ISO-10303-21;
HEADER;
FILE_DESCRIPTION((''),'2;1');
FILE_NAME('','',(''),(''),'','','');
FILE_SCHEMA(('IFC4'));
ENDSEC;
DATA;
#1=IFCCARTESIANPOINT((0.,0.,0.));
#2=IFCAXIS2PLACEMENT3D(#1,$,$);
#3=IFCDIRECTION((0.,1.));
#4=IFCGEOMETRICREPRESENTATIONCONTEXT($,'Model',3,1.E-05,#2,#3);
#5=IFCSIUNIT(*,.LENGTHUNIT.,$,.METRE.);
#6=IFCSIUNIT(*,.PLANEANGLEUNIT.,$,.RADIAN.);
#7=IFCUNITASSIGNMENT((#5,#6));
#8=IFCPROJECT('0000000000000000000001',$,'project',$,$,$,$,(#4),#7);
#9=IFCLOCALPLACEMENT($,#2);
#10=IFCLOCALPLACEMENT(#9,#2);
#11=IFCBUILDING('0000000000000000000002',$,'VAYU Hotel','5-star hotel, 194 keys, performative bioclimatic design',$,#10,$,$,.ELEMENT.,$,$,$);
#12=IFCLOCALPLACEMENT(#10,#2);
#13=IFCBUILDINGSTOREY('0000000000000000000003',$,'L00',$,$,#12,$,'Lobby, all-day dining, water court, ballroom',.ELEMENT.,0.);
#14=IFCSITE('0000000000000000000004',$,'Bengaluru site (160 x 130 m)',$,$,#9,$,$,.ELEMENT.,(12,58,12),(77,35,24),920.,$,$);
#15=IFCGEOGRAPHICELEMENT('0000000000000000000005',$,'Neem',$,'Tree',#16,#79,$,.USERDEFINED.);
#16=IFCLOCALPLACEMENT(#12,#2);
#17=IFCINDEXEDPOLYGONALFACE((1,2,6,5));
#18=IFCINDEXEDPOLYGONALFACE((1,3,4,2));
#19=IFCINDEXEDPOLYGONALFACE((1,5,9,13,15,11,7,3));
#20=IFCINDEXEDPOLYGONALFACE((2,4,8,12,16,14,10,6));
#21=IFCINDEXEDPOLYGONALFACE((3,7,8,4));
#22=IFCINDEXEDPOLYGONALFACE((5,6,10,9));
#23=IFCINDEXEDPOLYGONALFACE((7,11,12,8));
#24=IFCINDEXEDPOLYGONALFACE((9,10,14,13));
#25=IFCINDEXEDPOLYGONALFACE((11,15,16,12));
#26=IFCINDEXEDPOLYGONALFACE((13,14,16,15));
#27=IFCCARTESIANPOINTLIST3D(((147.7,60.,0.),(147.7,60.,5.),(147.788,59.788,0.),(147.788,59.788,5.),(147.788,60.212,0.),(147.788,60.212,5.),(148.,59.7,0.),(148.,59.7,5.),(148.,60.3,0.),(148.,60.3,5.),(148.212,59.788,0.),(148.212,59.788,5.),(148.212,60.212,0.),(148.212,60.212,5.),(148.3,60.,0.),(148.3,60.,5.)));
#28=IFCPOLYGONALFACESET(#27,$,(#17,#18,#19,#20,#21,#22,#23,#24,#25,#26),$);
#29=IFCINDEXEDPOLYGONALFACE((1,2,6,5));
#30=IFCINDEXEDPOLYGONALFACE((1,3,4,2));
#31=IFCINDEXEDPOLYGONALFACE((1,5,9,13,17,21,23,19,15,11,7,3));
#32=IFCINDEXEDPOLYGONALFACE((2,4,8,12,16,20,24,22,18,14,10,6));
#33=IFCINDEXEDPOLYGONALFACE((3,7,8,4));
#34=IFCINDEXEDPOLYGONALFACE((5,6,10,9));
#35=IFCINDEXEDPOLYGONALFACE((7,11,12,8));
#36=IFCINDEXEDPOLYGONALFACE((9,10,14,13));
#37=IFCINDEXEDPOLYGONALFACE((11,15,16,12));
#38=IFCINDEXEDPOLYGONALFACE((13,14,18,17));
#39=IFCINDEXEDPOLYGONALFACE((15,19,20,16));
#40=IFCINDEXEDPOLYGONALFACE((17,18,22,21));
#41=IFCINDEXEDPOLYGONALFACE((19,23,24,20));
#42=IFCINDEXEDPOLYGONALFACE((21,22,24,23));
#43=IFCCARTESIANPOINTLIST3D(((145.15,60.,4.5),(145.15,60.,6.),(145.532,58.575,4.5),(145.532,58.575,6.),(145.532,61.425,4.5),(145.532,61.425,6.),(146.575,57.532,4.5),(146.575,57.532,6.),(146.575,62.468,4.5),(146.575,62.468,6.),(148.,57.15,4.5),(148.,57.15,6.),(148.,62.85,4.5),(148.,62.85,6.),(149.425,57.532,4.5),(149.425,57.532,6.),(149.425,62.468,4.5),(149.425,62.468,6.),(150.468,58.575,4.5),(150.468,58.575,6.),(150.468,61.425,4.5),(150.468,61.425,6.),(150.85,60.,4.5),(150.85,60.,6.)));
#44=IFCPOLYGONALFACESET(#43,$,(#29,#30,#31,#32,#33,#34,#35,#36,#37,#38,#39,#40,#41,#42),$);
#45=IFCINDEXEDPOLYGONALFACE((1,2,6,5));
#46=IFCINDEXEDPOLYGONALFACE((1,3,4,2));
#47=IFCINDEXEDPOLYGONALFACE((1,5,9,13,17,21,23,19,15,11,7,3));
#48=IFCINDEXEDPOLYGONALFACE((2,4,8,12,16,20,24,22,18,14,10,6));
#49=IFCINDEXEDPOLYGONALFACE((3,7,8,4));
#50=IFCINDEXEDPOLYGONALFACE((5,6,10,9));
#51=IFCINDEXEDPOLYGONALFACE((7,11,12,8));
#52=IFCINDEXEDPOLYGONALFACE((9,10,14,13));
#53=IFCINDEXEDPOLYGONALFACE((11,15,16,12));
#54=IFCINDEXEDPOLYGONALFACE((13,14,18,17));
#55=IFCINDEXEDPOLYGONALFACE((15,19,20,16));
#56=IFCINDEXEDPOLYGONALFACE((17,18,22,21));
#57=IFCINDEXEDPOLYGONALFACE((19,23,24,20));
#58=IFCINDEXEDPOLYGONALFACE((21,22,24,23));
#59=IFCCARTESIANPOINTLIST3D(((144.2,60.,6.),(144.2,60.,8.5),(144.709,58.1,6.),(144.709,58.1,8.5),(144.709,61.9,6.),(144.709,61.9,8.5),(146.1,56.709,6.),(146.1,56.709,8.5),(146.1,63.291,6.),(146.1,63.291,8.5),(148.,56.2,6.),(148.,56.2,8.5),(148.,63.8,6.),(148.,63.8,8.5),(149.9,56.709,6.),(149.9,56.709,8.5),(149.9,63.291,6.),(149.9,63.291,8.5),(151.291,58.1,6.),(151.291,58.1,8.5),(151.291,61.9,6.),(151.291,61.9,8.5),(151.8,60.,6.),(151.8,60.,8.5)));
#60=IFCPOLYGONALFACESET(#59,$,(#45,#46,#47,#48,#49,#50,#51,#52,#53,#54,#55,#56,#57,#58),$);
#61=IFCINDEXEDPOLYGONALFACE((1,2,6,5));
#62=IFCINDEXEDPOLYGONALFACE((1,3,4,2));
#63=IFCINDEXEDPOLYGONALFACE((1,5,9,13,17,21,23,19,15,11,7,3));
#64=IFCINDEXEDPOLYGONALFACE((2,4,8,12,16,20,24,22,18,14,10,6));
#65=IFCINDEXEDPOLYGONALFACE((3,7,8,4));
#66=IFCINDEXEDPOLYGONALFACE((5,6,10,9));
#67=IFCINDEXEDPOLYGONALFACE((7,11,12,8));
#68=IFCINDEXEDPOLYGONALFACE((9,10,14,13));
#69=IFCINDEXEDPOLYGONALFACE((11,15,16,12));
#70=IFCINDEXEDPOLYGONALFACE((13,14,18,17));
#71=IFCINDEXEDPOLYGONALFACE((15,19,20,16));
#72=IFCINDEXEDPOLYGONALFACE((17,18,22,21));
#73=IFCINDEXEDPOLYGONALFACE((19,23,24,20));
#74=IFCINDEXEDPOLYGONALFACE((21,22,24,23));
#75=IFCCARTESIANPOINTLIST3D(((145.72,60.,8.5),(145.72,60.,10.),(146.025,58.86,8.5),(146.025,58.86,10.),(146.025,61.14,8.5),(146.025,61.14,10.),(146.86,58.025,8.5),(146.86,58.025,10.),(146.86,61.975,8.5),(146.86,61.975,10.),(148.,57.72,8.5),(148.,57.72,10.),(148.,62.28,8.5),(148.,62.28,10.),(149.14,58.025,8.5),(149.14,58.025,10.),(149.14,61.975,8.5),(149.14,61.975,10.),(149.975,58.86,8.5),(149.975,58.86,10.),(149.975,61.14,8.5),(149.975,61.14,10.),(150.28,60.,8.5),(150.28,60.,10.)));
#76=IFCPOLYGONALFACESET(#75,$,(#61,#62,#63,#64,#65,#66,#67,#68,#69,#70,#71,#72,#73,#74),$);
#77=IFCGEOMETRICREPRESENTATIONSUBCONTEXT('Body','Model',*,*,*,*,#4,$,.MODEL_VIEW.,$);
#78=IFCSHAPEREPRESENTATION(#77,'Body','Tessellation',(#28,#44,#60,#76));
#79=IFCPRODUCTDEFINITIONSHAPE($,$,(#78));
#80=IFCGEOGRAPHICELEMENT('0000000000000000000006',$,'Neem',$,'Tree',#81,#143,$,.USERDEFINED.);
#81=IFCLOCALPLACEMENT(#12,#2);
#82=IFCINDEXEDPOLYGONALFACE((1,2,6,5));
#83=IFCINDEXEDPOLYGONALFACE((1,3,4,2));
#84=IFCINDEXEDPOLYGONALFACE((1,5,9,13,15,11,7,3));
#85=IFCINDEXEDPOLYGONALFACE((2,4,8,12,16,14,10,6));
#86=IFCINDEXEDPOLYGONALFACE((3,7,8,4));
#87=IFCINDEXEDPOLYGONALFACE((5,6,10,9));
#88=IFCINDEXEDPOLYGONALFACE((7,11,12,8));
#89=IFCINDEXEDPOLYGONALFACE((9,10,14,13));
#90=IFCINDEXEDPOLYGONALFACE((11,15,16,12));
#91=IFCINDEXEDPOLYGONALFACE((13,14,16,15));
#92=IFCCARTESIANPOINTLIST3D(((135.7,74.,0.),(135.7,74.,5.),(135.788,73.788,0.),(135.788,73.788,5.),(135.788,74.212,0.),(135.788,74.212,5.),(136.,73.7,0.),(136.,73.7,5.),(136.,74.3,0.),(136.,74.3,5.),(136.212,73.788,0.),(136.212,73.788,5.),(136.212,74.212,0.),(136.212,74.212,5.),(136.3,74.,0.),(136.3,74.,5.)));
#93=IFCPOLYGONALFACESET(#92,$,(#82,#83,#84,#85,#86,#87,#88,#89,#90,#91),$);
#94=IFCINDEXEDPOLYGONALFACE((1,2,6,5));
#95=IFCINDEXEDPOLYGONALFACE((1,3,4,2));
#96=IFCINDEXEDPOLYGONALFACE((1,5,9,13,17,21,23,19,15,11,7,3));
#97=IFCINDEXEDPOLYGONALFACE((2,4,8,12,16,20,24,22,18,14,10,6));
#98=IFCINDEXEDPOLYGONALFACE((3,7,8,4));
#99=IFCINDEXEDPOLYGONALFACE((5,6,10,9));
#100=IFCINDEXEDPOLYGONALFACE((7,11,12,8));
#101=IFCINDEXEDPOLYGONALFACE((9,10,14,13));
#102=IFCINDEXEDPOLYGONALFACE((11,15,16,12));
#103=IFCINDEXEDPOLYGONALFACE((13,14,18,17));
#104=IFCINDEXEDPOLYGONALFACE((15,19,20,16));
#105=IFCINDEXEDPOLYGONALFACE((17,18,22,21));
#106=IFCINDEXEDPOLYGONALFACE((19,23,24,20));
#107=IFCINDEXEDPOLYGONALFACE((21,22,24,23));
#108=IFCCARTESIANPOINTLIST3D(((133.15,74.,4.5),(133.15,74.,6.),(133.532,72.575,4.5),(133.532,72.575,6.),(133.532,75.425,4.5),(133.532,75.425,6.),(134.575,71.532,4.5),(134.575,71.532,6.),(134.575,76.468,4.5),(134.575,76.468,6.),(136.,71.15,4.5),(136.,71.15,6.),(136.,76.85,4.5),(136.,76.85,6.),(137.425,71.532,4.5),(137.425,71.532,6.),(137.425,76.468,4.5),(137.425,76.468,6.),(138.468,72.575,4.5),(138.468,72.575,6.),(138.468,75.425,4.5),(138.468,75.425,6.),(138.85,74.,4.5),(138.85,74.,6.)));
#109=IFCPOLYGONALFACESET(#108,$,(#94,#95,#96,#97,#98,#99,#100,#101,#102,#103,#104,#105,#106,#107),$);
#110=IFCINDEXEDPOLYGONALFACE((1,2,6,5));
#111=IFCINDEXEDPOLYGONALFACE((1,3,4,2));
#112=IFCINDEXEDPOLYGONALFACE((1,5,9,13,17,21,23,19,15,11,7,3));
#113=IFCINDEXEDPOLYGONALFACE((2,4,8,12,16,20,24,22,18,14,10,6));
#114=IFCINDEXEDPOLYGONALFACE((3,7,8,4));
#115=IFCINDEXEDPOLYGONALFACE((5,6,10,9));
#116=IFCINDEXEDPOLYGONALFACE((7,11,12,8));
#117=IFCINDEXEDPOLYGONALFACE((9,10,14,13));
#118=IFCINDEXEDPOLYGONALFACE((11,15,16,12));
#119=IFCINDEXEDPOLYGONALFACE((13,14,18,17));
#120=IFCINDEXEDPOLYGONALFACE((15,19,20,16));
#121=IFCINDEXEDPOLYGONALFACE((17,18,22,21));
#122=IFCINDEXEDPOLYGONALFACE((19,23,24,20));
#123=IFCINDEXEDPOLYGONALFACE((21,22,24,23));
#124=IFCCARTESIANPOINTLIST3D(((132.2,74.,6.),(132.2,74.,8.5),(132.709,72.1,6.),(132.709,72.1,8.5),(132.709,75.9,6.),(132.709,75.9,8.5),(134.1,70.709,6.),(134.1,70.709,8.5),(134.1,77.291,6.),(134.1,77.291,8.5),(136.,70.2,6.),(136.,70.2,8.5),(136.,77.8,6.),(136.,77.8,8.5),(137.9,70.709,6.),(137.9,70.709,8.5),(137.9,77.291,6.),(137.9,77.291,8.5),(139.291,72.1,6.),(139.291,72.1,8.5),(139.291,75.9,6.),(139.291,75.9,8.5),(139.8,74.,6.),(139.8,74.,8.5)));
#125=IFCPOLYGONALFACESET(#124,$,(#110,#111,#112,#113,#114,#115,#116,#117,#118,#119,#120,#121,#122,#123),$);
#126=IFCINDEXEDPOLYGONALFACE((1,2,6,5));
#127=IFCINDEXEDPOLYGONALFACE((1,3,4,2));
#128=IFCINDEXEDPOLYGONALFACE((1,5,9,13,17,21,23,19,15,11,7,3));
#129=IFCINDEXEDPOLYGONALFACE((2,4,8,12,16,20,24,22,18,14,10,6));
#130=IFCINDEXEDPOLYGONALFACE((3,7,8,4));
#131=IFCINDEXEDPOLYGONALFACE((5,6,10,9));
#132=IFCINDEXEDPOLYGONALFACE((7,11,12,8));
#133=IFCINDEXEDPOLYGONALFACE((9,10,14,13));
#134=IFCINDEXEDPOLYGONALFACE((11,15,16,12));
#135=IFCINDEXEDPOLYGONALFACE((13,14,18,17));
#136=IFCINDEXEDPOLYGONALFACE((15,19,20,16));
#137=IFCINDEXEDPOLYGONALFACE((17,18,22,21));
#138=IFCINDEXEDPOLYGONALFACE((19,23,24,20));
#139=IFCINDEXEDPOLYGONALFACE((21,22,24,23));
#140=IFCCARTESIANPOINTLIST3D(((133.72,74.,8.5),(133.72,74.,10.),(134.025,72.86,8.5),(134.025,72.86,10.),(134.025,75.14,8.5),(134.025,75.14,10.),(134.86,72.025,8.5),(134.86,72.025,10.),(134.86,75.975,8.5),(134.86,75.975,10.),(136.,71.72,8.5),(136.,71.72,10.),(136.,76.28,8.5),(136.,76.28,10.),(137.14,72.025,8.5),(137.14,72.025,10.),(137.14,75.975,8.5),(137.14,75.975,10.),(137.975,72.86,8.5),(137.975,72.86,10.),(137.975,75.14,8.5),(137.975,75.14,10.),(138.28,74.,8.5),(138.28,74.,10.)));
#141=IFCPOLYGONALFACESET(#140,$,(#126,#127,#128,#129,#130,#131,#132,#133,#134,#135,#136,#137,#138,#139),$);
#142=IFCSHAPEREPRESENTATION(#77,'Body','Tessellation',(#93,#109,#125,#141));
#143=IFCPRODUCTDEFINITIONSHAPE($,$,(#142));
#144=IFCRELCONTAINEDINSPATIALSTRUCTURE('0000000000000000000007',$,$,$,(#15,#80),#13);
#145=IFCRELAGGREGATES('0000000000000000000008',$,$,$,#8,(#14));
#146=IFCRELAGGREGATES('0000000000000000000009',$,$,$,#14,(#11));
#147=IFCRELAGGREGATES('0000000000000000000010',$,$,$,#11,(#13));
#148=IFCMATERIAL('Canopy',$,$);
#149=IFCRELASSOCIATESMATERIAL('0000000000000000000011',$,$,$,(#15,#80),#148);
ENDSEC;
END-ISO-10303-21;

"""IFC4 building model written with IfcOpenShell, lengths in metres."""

from ifc_helpers import new_model, si_unit, direction, frame, origin, place, context, subcontext, project, spatial, polyline, outline, extrude, material, element, save


model = new_model("IFC4")

# Units and contexts
model_context = context("Model", 3, precision=1e-05, world=origin(), true_north=direction((0.0, 1.0)))
body_context = subcontext(model_context, "Body", "Model", "MODEL_VIEW")
ifc_project = project(units=[si_unit("LENGTHUNIT", "METRE"), si_unit("PLANEANGLEUNIT", "RADIAN")], contexts=[model_context])

# Site, building, storey
site_placement = place(None, origin())
site = spatial("IfcSite", under=ifc_project, at=site_placement, Name="Bengaluru site (160 x 130 m)", CompositionType="ELEMENT", RefLatitude=(12, 58, 12), RefLongitude=(77, 35, 24), RefElevation=920.0)
building_placement = place(site_placement, origin())
building = spatial("IfcBuilding", under=site, at=building_placement, Name="VAYU Hotel", Description="5-star hotel, 194 keys, performative bioclimatic design", CompositionType="ELEMENT")
storey_placement = place(building_placement, origin())
storey = spatial("IfcBuildingStorey", under=building, at=storey_placement, Name="L00", LongName="Lobby, all-day dining, water court, ballroom", CompositionType="ELEMENT", Elevation=0.0)

# Geographic elements
ifc_material_1 = material(Name="Canopy")
geographic_element_1_placement = place(storey_placement, origin())
element("IfcGeographicElement", 1, at=geographic_element_1_placement, inside=storey, material=ifc_material_1, Name="Neem", ObjectType="Tree", PredefinedType="USERDEFINED", context=body_context, shape_type="SweptSolid", body=[
    extrude(outline(polyline([(148.3, 60.0), (148.212, 60.212), (148.0, 60.3), (147.788, 60.212), (147.7, 60.0), (147.788, 59.788), (148.0, 59.7), (148.212, 59.788), (148.3, 60.0)])), origin(), (0.0, 0.0, 1.0), 5.0),
    extrude(outline(polyline([(150.85, 60.0), (150.468, 61.425), (149.425, 62.468), (148.0, 62.85), (146.575, 62.468), (145.532, 61.425), (145.15, 60.0), (145.532, 58.575), (146.575, 57.532), (148.0, 57.15), (149.425, 57.532), (150.468, 58.575), (150.85, 60.0)])), frame((0.0, 0.0, 4.5)), (0.0, 0.0, 1.0), 1.5),
    extrude(outline(polyline([(151.8, 60.0), (151.291, 61.9), (149.9, 63.291), (148.0, 63.8), (146.1, 63.291), (144.709, 61.9), (144.2, 60.0), (144.709, 58.1), (146.1, 56.709), (148.0, 56.2), (149.9, 56.709), (151.291, 58.1), (151.8, 60.0)])), frame((0.0, 0.0, 6.0)), (0.0, 0.0, 1.0), 2.5),
    extrude(outline(polyline([(150.28, 60.0), (149.975, 61.14), (149.14, 61.975), (148.0, 62.28), (146.86, 61.975), (146.025, 61.14), (145.72, 60.0), (146.025, 58.86), (146.86, 58.025), (148.0, 57.72), (149.14, 58.025), (149.975, 58.86), (150.28, 60.0)])), frame((0.0, 0.0, 8.5)), (0.0, 0.0, 1.0), 1.5),
])
geographic_element_2_placement = place(storey_placement, origin())
element("IfcGeographicElement", 2, at=geographic_element_2_placement, inside=storey, material=ifc_material_1, Name="Neem", ObjectType="Tree", PredefinedType="USERDEFINED", context=body_context, shape_type="SweptSolid", body=[
    extrude(outline(polyline([(136.3, 74.0), (136.212, 74.212), (136.0, 74.3), (135.788, 74.212), (135.7, 74.0), (135.788, 73.788), (136.0, 73.7), (136.212, 73.788), (136.3, 74.0)])), origin(), (0.0, 0.0, 1.0), 5.0),
    extrude(outline(polyline([(138.85, 74.0), (138.468, 75.425), (137.425, 76.468), (136.0, 76.85), (134.575, 76.468), (133.532, 75.425), (133.15, 74.0), (133.532, 72.575), (134.575, 71.532), (136.0, 71.15), (137.425, 71.532), (138.468, 72.575), (138.85, 74.0)])), frame((0.0, 0.0, 4.5)), (0.0, 0.0, 1.0), 1.5),
    extrude(outline(polyline([(139.8, 74.0), (139.291, 75.9), (137.9, 77.291), (136.0, 77.8), (134.1, 77.291), (132.709, 75.9), (132.2, 74.0), (132.709, 72.1), (134.1, 70.709), (136.0, 70.2), (137.9, 70.709), (139.291, 72.1), (139.8, 74.0)])), frame((0.0, 0.0, 6.0)), (0.0, 0.0, 1.0), 2.5),
    extrude(outline(polyline([(138.28, 74.0), (137.975, 75.14), (137.14, 75.975), (136.0, 76.28), (134.86, 75.975), (134.025, 75.14), (133.72, 74.0), (134.025, 72.86), (134.86, 72.025), (136.0, 71.72), (137.14, 72.025), (137.975, 72.86), (138.28, 74.0)])), frame((0.0, 0.0, 8.5)), (0.0, 0.0, 1.0), 1.5),
])

save(model, "model.ifc")
